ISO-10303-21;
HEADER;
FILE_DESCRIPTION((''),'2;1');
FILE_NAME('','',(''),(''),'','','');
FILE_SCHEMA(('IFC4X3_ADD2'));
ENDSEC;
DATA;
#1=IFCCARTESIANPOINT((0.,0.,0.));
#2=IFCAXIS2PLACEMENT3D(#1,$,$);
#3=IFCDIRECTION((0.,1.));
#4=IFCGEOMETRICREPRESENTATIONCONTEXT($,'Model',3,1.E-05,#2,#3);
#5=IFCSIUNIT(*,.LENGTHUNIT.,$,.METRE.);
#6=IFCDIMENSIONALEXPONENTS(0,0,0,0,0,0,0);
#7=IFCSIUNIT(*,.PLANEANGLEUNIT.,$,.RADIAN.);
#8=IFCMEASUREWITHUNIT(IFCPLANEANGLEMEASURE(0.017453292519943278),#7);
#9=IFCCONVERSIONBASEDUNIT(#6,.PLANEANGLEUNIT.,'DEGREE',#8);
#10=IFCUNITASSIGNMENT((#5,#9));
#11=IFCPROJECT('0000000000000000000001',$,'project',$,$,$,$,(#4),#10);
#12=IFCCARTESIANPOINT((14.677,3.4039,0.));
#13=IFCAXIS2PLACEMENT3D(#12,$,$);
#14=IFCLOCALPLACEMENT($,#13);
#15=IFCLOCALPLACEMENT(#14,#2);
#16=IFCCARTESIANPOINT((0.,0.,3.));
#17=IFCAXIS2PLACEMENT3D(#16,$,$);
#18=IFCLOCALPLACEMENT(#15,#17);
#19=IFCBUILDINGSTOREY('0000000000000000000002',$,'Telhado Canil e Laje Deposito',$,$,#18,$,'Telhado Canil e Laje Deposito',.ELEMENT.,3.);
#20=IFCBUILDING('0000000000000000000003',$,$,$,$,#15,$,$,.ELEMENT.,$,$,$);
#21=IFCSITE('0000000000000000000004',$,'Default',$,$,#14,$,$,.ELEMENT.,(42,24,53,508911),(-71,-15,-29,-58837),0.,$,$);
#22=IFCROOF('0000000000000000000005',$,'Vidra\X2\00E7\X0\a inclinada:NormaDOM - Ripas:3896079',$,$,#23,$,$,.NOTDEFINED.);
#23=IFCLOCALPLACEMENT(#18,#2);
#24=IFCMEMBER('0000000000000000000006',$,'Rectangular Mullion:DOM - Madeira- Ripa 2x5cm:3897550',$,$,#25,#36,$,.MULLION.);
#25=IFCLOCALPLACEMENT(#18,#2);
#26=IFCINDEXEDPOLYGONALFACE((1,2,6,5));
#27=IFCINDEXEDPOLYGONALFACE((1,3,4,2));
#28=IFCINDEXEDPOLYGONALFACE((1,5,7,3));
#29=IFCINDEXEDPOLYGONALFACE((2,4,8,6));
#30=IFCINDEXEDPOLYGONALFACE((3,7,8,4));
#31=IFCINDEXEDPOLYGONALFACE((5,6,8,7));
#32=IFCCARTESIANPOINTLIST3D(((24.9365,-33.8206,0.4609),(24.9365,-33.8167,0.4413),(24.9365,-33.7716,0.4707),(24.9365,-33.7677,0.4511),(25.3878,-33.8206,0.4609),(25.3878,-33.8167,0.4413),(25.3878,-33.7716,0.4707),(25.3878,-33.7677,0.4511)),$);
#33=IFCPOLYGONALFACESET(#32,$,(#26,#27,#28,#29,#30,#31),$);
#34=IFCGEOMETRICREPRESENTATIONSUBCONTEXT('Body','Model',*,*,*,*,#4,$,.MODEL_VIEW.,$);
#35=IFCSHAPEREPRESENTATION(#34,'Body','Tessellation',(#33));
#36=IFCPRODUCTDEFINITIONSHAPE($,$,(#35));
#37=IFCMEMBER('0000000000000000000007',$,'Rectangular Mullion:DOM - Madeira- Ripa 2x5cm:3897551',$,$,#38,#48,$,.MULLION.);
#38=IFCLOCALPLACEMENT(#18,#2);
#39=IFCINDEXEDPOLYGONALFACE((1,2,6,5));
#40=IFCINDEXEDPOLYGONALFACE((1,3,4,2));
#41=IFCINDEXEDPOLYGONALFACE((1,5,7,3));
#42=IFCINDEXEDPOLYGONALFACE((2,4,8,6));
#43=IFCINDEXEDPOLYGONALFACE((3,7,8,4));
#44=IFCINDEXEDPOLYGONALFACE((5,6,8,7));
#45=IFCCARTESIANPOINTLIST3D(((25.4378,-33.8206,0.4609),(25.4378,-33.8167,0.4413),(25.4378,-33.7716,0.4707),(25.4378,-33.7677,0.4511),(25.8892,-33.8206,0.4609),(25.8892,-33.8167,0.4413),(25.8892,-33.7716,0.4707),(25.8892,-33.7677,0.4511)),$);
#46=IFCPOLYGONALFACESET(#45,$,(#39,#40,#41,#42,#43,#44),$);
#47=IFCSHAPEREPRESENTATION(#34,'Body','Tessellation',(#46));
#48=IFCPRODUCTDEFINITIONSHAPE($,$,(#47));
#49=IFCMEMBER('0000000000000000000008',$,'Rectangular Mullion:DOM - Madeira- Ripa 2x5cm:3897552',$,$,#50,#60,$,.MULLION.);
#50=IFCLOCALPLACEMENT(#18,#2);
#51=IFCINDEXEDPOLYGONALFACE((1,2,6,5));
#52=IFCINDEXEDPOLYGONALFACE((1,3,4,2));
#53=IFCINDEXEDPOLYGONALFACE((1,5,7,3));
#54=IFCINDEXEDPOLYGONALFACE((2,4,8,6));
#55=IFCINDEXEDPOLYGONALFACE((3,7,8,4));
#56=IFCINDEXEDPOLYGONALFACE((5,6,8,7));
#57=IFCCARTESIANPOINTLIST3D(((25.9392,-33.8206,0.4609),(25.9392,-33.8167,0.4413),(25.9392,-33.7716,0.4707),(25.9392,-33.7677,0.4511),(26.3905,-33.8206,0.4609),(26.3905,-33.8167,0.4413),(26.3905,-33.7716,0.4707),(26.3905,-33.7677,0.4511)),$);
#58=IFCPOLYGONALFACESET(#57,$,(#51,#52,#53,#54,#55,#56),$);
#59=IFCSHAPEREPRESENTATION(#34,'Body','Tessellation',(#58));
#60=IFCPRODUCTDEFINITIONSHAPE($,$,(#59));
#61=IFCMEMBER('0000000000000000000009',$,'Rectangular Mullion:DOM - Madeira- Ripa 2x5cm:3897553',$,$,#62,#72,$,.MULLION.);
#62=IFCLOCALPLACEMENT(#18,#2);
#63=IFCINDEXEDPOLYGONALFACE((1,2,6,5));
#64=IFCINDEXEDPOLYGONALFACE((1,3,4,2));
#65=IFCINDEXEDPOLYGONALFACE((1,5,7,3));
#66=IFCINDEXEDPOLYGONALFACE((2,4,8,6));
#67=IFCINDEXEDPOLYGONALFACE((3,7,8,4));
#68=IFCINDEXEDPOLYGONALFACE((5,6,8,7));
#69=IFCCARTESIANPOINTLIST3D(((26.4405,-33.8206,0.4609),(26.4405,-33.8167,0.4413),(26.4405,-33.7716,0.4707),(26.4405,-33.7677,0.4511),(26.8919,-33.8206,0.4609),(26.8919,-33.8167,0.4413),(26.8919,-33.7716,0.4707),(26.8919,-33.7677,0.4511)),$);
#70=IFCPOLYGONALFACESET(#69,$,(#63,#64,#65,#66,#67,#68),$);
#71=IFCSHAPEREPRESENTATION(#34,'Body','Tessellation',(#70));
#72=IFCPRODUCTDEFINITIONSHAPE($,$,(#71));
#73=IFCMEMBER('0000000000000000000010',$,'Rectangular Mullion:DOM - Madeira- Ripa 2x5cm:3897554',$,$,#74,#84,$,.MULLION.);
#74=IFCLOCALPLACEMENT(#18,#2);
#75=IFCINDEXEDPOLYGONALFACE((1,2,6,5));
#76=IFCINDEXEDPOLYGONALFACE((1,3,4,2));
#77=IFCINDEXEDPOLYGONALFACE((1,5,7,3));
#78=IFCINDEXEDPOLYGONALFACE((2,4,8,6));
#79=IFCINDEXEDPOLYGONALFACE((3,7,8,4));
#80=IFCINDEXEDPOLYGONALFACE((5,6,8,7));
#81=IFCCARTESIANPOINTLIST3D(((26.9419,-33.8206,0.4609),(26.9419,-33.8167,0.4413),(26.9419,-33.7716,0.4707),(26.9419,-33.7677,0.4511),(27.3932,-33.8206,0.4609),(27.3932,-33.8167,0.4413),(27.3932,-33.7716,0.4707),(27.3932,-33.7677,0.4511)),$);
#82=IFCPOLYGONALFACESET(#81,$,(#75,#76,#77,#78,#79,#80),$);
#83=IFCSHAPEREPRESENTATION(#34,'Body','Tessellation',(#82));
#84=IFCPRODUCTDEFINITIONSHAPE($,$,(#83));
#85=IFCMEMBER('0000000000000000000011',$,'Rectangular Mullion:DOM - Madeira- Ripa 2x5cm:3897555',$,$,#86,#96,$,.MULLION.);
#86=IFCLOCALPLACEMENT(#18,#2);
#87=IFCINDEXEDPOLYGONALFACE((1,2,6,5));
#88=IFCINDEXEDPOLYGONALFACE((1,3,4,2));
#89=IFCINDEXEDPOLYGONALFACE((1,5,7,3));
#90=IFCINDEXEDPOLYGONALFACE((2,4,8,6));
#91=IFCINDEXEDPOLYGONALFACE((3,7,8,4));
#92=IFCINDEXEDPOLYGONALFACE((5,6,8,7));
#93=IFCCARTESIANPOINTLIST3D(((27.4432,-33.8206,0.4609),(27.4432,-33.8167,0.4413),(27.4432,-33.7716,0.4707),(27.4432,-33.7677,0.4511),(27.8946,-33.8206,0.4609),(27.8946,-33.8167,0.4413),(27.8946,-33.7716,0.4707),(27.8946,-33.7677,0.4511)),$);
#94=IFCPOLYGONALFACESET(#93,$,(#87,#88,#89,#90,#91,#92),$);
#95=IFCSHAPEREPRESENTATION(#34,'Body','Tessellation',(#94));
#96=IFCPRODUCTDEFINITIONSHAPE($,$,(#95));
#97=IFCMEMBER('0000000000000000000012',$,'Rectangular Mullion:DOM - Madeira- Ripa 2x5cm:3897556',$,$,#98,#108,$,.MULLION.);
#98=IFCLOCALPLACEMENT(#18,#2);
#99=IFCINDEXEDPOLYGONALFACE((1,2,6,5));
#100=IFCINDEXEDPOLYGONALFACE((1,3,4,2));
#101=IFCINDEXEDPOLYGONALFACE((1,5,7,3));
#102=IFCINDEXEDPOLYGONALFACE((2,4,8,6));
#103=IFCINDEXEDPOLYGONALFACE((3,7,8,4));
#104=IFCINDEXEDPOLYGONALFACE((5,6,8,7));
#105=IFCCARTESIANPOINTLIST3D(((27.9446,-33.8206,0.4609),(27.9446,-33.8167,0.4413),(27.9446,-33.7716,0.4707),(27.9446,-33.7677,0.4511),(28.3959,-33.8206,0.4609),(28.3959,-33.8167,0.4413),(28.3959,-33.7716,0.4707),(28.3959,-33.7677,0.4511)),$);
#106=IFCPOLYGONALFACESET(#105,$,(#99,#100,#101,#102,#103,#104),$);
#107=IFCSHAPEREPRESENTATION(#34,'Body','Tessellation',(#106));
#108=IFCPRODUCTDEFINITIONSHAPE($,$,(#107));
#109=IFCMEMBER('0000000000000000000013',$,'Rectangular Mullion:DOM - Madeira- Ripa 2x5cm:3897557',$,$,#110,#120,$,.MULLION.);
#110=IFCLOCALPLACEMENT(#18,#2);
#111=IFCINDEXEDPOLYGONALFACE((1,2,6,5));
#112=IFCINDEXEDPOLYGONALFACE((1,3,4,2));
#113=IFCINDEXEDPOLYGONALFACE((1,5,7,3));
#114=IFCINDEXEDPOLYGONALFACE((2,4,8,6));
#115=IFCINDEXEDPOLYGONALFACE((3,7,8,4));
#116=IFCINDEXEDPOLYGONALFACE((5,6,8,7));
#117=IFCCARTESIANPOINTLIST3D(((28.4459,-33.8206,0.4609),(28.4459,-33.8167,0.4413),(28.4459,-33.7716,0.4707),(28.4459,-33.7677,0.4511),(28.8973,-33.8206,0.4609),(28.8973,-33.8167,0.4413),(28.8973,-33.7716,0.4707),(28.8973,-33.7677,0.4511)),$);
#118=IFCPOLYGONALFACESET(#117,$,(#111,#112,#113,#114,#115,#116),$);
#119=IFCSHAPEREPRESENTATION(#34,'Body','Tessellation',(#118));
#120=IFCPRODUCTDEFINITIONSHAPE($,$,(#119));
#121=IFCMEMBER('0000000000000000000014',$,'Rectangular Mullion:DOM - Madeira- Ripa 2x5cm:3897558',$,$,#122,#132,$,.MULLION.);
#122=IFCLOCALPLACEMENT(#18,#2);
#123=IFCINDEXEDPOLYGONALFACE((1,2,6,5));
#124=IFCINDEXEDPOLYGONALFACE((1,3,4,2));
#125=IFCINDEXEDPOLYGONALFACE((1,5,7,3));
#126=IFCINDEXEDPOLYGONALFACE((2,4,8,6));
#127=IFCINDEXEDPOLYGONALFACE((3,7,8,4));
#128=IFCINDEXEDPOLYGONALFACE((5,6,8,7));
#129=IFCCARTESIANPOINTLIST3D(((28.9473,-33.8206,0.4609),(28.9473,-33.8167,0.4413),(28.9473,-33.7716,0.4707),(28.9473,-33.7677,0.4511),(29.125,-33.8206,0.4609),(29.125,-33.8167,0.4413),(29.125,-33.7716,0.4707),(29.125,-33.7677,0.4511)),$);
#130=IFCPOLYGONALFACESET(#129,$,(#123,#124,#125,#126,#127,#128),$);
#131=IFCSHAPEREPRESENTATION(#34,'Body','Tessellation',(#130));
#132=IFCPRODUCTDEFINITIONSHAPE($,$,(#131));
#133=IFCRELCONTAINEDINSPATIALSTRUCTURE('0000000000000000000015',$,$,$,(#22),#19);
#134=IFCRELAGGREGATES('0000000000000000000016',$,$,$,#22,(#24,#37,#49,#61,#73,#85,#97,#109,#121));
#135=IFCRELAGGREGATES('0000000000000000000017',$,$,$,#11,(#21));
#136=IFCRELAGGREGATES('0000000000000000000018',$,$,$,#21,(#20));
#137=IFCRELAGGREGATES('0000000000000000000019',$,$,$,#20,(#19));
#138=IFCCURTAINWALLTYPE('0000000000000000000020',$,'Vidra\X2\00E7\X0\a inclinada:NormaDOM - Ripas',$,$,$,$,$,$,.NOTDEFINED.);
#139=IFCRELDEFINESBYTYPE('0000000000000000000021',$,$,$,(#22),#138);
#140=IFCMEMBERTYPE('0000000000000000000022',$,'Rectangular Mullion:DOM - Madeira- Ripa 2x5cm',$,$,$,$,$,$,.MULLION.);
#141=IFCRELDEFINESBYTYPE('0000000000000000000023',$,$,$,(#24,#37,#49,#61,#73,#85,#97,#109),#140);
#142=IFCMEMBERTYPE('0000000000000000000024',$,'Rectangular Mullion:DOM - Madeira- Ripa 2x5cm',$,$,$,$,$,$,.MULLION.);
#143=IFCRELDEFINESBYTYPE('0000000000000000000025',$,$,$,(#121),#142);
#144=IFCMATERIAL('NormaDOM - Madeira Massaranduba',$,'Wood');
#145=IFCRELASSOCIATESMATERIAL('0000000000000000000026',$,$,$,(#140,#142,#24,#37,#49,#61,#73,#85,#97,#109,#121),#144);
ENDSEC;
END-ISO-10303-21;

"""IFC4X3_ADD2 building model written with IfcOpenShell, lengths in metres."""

from ifc_helpers import new_model, entity, si_unit, converted_unit, direction, frame, origin, origin_2d_with_axis, place, context, subcontext, project, spatial, rectangle, extrude, source, transform, mapped, material, material_profile, profile_set, profile_usage, type_object, type_shapes, element, aggregate, save


model = new_model("IFC4X3_ADD2")

# Units and contexts
model_context = context("Model", 3, precision=1e-05, world=origin(), true_north=direction((0.0, 1.0)))
body_context = subcontext(model_context, "Body", "Model", "MODEL_VIEW")
ifc_project = project(units=[si_unit("LENGTHUNIT", "METRE"), converted_unit("PLANEANGLEUNIT", "DEGREE", entity("IfcPlaneAngleMeasure", 0.017453292519943278), si_unit("PLANEANGLEUNIT", "RADIAN"), dimensions=[0, 0, 0, 0, 0, 0, 0])], contexts=[model_context])

# Site, building, storey
site_placement = place(None, frame((14.677, 3.4039, 0.0)))
site = spatial("IfcSite", under=ifc_project, at=site_placement, Name="Default", CompositionType="ELEMENT", RefLatitude=(42, 24, 53, 508911), RefLongitude=(-71, -15, -29, -58837), RefElevation=0.0)
building_placement = place(site_placement, origin())
building = spatial("IfcBuilding", under=site, at=building_placement, CompositionType="ELEMENT")
storey_placement = place(building_placement, frame((0.0, 0.0, 3.0)))
storey = spatial("IfcBuildingStorey", under=building, at=storey_placement, Name="Telhado Canil e Laje Deposito", LongName="Telhado Canil e Laje Deposito", CompositionType="ELEMENT", Elevation=3.0)

# Roof, members
curtain_wall_type = type_object("IfcCurtainWallType", Name="Vidraça inclinada:NormaDOM - Ripas", PredefinedType="NOTDEFINED")
roof_placement = place(storey_placement, frame((0.0, 0.0, -3.0)))
roof = element("IfcRoof", 1, at=roof_placement, inside=storey, type_object=curtain_wall_type, Name="Vidraça inclinada:NormaDOM - Ripas:3896079", PredefinedType="NOTDEFINED")
ifc_material = material(Name="NormaDOM - Madeira Massaranduba", Category="Wood")
ifc_material_profile_1 = material_profile(ifc_material, rectangle(XDim=0.05, YDim=0.02, at=origin_2d_with_axis()), Name="DOM - Madeira- Ripa 2x5cm")
ifc_profile_set_1 = profile_set([ifc_material_profile_1], Name="DOM - Madeira- Ripa 2x5cm")
ifc_profile_usage_1 = profile_usage(ifc_profile_set_1)
member_type_1 = type_object("IfcMemberType", Name="Rectangular Mullion:DOM - Madeira- Ripa 2x5cm", PredefinedType="MULLION", material=ifc_profile_set_1)
shared_shape_1 = source(origin(), body_context, "Body", "SweptSolid", [
    extrude(rectangle(XDim=0.05, YDim=0.02, at=origin_2d_with_axis()), frame((0.025, 0.01, -0.4514), z_axis=(0.0, 0.0, 1.0), x_axis=(-1.0, 0.0, 0.0)), (0.0, 0.0, 1.0), 0.4514),
])
type_shapes(member_type_1, [shared_shape_1])
member_1_placement = place(roof_placement, frame((24.9365, -33.8206, 3.4609), z_axis=(-1.0, 0.0, 0.0), x_axis=(0.0, 0.980581, 0.196116)))
member_1 = element("IfcMember", 2, at=member_1_placement, type_object=member_type_1, material=ifc_profile_usage_1, Name="Rectangular Mullion:DOM - Madeira- Ripa 2x5cm:3897550", PredefinedType="MULLION", context=body_context, shape_type="MappedRepresentation", body=[
    mapped(shared_shape_1, transform((0.0, 0.0, 0.0), scale=1.0)),
])
member_2_placement = place(roof_placement, frame((25.4378, -33.8206, 3.4609), z_axis=(-1.0, 0.0, 0.0), x_axis=(0.0, 0.980581, 0.196116)))
member_2 = element("IfcMember", 3, at=member_2_placement, type_object=member_type_1, material=ifc_profile_usage_1, Name="Rectangular Mullion:DOM - Madeira- Ripa 2x5cm:3897551", PredefinedType="MULLION", context=body_context, shape_type="MappedRepresentation", body=[
    mapped(shared_shape_1, transform((0.0, 0.0, 0.0), scale=1.0)),
])
member_3_placement = place(roof_placement, frame((25.9392, -33.8206, 3.4609), z_axis=(-1.0, 0.0, 0.0), x_axis=(0.0, 0.980581, 0.196116)))
member_3 = element("IfcMember", 4, at=member_3_placement, type_object=member_type_1, material=ifc_profile_usage_1, Name="Rectangular Mullion:DOM - Madeira- Ripa 2x5cm:3897552", PredefinedType="MULLION", context=body_context, shape_type="MappedRepresentation", body=[
    mapped(shared_shape_1, transform((0.0, 0.0, 0.0), scale=1.0)),
])
member_4_placement = place(roof_placement, frame((26.4405, -33.8206, 3.4609), z_axis=(-1.0, 0.0, 0.0), x_axis=(0.0, 0.980581, 0.196116)))
member_4 = element("IfcMember", 5, at=member_4_placement, type_object=member_type_1, material=ifc_profile_usage_1, Name="Rectangular Mullion:DOM - Madeira- Ripa 2x5cm:3897553", PredefinedType="MULLION", context=body_context, shape_type="MappedRepresentation", body=[
    mapped(shared_shape_1, transform((0.0, 0.0, 0.0), scale=1.0)),
])
member_5_placement = place(roof_placement, frame((26.9419, -33.8206, 3.4609), z_axis=(-1.0, 0.0, 0.0), x_axis=(0.0, 0.980581, 0.196116)))
member_5 = element("IfcMember", 6, at=member_5_placement, type_object=member_type_1, material=ifc_profile_usage_1, Name="Rectangular Mullion:DOM - Madeira- Ripa 2x5cm:3897554", PredefinedType="MULLION", context=body_context, shape_type="MappedRepresentation", body=[
    mapped(shared_shape_1, transform((0.0, 0.0, 0.0), scale=1.0)),
])
member_6_placement = place(roof_placement, frame((27.4432, -33.8206, 3.4609), z_axis=(-1.0, 0.0, 0.0), x_axis=(0.0, 0.980581, 0.196116)))
member_6 = element("IfcMember", 7, at=member_6_placement, type_object=member_type_1, material=ifc_profile_usage_1, Name="Rectangular Mullion:DOM - Madeira- Ripa 2x5cm:3897555", PredefinedType="MULLION", context=body_context, shape_type="MappedRepresentation", body=[
    mapped(shared_shape_1, transform((0.0, 0.0, 0.0), scale=1.0)),
])
member_7_placement = place(roof_placement, frame((27.9446, -33.8206, 3.4609), z_axis=(-1.0, 0.0, 0.0), x_axis=(0.0, 0.980581, 0.196116)))
member_7 = element("IfcMember", 8, at=member_7_placement, type_object=member_type_1, material=ifc_profile_usage_1, Name="Rectangular Mullion:DOM - Madeira- Ripa 2x5cm:3897556", PredefinedType="MULLION", context=body_context, shape_type="MappedRepresentation", body=[
    mapped(shared_shape_1, transform((0.0, 0.0, 0.0), scale=1.0)),
])
member_8_placement = place(roof_placement, frame((28.4459, -33.8206, 3.4609), z_axis=(-1.0, 0.0, 0.0), x_axis=(0.0, 0.980581, 0.196116)))
member_8 = element("IfcMember", 9, at=member_8_placement, type_object=member_type_1, material=ifc_profile_usage_1, Name="Rectangular Mullion:DOM - Madeira- Ripa 2x5cm:3897557", PredefinedType="MULLION", context=body_context, shape_type="MappedRepresentation", body=[
    mapped(shared_shape_1, transform((0.0, 0.0, 0.0), scale=1.0)),
])
member_type_2 = type_object("IfcMemberType", Name="Rectangular Mullion:DOM - Madeira- Ripa 2x5cm", PredefinedType="MULLION", material=ifc_profile_set_1)
shared_shape_2 = source(origin(), body_context, "Body", "SweptSolid", [
    extrude(rectangle(XDim=0.05, YDim=0.02, at=origin_2d_with_axis()), frame((0.025, 0.01, -0.1777), z_axis=(0.0, 0.0, 1.0), x_axis=(-1.0, 0.0, 0.0)), (0.0, 0.0, 1.0), 0.1777),
])
type_shapes(member_type_2, [shared_shape_2])
member_9_placement = place(roof_placement, frame((28.9473, -33.8206, 3.4609), z_axis=(-1.0, 0.0, 0.0), x_axis=(0.0, 0.980581, 0.196116)))
member_9 = element("IfcMember", 10, at=member_9_placement, type_object=member_type_2, material=ifc_profile_usage_1, Name="Rectangular Mullion:DOM - Madeira- Ripa 2x5cm:3897558", PredefinedType="MULLION", context=body_context, shape_type="MappedRepresentation", body=[
    mapped(shared_shape_2, transform((0.0, 0.0, 0.0), scale=1.0)),
])
aggregate(roof, [member_1, member_2, member_3, member_4, member_5, member_6, member_7, member_8, member_9])

save(model, "model.ifc")
